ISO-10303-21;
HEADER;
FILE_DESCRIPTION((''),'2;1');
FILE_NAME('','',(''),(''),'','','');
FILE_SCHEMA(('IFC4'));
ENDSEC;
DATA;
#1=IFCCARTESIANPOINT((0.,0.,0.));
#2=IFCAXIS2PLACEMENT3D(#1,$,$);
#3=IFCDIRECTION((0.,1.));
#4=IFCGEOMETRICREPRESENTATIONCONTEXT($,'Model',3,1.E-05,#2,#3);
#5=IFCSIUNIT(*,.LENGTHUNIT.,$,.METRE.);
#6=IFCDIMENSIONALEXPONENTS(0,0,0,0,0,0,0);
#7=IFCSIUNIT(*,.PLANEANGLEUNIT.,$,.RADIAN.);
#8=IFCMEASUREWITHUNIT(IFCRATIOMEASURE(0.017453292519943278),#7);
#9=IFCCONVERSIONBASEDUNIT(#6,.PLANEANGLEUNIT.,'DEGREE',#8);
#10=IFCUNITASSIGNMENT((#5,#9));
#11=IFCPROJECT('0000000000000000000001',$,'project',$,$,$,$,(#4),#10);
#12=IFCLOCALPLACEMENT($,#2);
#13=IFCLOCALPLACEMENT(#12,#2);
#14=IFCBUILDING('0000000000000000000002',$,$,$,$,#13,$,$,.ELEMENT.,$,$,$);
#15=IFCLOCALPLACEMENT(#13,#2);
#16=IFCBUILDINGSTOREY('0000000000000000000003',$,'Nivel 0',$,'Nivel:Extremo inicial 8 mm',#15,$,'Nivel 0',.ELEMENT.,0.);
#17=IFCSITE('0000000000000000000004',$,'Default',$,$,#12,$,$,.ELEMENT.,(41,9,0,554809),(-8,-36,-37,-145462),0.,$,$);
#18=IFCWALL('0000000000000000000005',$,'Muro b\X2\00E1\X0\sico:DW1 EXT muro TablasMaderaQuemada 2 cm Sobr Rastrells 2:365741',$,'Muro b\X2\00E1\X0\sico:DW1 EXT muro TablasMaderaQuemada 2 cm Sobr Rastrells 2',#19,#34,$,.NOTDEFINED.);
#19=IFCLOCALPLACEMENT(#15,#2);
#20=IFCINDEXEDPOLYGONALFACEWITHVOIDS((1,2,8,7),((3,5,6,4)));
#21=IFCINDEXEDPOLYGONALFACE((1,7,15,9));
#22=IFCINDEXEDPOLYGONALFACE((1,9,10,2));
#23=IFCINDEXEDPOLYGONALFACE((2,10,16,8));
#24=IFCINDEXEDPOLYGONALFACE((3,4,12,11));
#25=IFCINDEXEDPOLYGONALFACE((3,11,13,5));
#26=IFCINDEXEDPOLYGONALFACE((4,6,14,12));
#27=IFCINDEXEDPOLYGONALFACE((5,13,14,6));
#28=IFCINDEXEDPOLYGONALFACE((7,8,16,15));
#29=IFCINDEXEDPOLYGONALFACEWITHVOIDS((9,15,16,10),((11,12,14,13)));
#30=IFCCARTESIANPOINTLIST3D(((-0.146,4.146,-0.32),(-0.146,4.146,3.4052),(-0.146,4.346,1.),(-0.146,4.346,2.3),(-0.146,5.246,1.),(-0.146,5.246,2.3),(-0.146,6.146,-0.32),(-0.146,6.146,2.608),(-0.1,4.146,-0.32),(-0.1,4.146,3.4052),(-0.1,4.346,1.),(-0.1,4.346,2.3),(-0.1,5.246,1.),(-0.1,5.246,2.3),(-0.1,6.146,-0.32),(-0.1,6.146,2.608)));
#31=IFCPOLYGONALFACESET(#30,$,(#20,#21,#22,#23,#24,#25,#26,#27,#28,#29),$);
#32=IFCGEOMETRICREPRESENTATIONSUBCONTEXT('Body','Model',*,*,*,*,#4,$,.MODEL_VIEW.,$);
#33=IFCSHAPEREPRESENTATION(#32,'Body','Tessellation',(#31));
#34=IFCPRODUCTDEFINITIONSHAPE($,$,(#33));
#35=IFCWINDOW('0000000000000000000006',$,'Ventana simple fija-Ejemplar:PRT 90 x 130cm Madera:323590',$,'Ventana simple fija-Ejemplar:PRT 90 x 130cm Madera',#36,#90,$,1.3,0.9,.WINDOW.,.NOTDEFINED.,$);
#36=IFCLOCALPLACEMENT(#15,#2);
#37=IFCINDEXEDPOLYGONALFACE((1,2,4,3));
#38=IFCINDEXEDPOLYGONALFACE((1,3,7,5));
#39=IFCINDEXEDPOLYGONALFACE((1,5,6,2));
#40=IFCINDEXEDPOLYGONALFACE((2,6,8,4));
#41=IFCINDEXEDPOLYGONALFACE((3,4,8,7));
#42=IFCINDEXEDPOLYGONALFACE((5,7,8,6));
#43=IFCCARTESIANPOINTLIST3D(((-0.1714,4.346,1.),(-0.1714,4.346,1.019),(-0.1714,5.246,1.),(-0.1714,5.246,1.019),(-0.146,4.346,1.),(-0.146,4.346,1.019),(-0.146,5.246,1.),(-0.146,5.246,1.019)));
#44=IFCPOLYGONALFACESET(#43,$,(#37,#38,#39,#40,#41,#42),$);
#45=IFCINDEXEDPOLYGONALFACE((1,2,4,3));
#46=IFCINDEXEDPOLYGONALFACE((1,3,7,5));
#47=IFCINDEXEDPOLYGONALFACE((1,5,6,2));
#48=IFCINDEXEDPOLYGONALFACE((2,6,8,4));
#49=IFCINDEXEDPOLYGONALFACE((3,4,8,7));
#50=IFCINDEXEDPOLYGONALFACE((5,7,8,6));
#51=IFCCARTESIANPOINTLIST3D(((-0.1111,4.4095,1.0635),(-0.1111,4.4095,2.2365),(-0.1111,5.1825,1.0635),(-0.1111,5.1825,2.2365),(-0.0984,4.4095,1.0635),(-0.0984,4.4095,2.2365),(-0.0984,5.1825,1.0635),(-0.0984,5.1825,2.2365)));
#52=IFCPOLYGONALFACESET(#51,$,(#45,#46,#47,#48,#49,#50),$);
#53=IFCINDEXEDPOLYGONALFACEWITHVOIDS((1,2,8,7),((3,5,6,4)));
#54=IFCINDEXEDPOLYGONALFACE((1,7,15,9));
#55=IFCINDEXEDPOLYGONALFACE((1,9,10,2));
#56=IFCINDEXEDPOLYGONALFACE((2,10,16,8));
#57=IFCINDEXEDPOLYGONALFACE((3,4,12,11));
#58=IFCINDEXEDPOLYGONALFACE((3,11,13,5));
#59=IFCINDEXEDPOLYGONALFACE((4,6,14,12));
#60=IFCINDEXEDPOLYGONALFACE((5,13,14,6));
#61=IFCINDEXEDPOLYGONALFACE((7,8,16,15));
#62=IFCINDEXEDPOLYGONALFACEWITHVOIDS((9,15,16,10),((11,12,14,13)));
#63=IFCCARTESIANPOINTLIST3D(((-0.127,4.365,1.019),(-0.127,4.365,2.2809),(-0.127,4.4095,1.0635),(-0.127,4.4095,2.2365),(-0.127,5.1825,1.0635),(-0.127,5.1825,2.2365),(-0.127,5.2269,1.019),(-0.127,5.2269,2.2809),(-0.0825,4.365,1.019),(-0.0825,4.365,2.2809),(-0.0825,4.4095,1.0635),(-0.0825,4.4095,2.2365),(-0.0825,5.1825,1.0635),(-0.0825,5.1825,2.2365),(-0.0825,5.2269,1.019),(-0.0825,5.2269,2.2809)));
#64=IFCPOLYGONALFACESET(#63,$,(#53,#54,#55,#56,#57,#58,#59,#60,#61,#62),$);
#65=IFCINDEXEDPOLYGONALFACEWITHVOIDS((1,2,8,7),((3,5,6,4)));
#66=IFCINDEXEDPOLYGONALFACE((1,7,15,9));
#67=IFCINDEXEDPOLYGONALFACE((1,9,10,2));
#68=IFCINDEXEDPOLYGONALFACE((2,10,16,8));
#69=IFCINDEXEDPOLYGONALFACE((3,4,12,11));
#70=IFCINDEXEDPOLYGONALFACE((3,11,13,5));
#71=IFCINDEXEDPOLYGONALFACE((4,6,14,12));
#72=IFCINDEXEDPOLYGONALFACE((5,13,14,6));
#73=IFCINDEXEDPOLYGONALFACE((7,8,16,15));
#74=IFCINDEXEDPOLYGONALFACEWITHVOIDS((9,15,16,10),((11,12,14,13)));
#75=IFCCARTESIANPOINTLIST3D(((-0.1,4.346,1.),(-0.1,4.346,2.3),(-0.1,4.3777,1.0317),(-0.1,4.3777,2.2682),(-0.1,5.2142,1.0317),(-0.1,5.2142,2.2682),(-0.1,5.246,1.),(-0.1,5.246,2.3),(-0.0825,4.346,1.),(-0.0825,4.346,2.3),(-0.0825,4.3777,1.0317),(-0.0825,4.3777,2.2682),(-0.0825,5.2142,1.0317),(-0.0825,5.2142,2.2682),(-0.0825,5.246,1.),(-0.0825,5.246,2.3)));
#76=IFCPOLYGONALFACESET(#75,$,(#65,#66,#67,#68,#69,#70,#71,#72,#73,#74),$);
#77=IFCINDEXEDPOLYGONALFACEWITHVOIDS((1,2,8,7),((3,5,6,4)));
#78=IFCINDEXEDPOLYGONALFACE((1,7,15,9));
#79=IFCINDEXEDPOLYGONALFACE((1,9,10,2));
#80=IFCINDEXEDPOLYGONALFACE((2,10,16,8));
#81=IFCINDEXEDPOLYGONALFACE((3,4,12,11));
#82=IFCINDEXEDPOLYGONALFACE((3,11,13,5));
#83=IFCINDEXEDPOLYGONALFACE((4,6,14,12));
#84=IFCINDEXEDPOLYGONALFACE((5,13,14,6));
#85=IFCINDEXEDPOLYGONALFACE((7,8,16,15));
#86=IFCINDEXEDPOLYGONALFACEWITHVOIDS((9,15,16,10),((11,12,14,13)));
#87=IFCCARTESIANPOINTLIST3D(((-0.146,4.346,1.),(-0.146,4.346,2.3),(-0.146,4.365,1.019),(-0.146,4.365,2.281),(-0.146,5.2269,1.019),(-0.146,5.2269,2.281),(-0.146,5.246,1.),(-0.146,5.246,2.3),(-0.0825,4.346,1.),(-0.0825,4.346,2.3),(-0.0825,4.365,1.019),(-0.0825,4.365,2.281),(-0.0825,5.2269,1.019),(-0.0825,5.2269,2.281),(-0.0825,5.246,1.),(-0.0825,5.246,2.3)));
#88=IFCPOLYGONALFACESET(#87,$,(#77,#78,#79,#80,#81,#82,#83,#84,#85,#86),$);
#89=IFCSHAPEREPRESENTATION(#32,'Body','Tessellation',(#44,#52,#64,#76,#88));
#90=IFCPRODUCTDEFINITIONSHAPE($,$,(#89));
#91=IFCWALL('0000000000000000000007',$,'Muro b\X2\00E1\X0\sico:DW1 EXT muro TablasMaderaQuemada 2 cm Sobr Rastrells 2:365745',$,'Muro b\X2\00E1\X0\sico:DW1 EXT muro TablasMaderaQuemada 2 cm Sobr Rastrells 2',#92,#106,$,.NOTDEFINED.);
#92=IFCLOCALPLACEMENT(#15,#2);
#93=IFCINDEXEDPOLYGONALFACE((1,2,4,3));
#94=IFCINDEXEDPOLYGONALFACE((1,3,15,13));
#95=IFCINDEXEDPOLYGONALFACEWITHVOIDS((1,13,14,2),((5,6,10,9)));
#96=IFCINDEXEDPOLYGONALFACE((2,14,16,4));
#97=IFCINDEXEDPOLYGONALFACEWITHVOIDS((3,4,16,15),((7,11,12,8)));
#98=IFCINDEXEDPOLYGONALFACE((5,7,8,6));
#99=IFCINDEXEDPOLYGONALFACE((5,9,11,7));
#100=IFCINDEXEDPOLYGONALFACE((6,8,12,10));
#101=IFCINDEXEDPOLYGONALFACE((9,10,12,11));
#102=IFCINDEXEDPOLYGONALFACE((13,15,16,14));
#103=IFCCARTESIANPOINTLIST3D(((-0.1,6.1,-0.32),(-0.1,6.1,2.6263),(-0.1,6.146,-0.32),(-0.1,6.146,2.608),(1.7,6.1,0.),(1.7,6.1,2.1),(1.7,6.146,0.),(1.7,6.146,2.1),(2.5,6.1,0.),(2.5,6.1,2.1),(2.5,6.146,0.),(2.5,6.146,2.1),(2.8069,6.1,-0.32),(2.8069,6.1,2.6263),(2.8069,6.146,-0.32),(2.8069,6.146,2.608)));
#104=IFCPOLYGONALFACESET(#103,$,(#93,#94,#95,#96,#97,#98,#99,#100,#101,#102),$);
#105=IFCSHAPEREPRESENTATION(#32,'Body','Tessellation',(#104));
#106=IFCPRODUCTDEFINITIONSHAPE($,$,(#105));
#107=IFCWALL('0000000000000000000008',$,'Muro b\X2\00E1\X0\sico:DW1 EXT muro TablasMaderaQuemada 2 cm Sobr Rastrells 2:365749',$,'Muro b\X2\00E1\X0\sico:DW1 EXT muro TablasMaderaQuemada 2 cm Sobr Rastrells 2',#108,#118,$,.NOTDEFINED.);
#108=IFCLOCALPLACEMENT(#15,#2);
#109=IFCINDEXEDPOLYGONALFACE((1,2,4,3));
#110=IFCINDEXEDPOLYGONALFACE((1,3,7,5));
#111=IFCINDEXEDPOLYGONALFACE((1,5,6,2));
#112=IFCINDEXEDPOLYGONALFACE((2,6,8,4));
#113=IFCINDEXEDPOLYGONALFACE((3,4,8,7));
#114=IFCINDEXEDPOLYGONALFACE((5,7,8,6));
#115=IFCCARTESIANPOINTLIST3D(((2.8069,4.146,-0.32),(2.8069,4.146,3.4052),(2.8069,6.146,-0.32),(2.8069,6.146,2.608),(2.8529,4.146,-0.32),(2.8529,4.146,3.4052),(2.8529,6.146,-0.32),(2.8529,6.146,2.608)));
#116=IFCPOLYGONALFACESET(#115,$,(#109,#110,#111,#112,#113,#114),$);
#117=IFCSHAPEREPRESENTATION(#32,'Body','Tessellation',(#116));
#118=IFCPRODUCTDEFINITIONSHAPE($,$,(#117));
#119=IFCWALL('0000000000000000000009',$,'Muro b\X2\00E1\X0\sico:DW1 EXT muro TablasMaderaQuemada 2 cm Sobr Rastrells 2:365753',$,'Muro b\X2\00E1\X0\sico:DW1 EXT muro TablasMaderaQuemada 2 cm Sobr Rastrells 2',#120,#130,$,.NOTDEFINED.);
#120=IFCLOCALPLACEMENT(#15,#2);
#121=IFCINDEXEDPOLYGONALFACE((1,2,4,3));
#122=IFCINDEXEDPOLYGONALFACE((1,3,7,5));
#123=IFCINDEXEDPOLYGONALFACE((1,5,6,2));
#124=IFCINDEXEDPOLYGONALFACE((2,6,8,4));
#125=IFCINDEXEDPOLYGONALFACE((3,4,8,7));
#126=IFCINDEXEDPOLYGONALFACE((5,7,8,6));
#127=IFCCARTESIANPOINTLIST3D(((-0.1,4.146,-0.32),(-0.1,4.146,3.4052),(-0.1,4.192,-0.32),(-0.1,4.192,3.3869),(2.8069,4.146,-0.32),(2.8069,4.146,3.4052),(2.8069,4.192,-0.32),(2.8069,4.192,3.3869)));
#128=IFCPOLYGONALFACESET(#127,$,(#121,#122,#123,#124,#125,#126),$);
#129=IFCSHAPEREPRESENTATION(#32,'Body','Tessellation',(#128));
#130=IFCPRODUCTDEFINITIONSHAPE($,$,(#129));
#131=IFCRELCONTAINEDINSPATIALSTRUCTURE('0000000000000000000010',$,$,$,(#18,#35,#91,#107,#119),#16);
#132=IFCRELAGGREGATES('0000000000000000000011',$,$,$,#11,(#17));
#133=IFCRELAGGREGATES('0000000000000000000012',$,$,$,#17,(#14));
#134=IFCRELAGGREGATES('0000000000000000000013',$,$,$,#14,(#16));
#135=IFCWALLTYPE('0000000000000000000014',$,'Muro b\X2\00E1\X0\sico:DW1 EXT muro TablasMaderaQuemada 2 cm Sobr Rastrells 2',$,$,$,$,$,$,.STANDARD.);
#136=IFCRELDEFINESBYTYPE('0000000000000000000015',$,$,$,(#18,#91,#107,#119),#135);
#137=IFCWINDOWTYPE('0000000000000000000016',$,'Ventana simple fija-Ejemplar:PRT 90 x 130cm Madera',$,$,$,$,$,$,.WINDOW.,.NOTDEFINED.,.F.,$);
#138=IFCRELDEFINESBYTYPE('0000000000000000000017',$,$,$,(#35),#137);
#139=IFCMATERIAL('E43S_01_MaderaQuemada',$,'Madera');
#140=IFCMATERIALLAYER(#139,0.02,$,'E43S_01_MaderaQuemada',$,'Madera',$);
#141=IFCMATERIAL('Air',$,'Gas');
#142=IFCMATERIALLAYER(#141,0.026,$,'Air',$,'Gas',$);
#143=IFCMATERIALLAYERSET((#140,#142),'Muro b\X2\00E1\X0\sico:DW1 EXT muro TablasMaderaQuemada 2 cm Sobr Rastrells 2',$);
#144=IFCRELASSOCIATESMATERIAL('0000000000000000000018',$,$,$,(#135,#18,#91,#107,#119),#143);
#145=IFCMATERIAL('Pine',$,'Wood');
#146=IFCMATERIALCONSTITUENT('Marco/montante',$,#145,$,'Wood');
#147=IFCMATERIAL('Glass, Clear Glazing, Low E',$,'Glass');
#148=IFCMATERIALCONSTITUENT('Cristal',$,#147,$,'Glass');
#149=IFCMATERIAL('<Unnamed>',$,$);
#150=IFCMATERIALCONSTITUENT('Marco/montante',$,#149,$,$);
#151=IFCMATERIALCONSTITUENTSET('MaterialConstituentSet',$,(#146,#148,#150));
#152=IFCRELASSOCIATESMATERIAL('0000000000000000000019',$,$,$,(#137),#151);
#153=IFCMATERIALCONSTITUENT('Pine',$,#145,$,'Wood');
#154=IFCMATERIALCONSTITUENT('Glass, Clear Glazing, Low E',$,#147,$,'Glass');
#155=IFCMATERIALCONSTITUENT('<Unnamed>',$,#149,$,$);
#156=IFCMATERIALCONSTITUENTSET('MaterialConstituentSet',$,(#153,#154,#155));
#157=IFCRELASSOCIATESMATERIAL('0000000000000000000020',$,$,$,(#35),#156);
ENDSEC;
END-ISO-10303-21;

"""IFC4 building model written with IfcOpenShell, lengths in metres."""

from ifc_helpers import new_model, entity, si_unit, converted_unit, direction, frame, frame_2d, origin, origin_2d_with_axis, place, context, subcontext, project, spatial, polyline, rectangle, outline, extrude, clip, bounded_halfspace, source, transform, mapped, material, layer, layer_set, layer_usage, constituent, constituent_set, type_object, type_shapes, element, fill, save


model = new_model("IFC4")

# Units and contexts
model_context = context("Model", 3, precision=1e-05, world=origin(), true_north=direction((0.0, 1.0)))
body_context = subcontext(model_context, "Body", "Model", "MODEL_VIEW")
ifc_project = project(units=[si_unit("LENGTHUNIT", "METRE"), converted_unit("PLANEANGLEUNIT", "DEGREE", entity("IfcRatioMeasure", 0.017453292519943278), si_unit("PLANEANGLEUNIT", "RADIAN"), dimensions=[0, 0, 0, 0, 0, 0, 0])], contexts=[model_context])

# Site, building, storey
site_placement = place(None, origin())
site = spatial("IfcSite", under=ifc_project, at=site_placement, Name="Default", CompositionType="ELEMENT", RefLatitude=(41, 9, 0, 554809), RefLongitude=(-8, -36, -37, -145462), RefElevation=0.0)
building_placement = place(site_placement, origin())
building = spatial("IfcBuilding", under=site, at=building_placement, CompositionType="ELEMENT")
storey_placement = place(building_placement, origin())
storey = spatial("IfcBuildingStorey", under=building, at=storey_placement, Name="Nivel 0", ObjectType="Nivel:Extremo inicial 8 mm", LongName="Nivel 0", CompositionType="ELEMENT", Elevation=0.0)

# Shared definitions
ifc_material_1 = material(Name="Pine", Category="Wood")
ifc_material_2 = material(Name="Glass, Clear Glazing, Low E", Category="Glass")
ifc_material_3 = material(Name="<Unnamed>")

# Wall, opening, window
ifc_material_4 = material(Name="E43S_01_MaderaQuemada", Category="Madera")
ifc_layer_1 = layer(ifc_material_4, 0.02, Name="E43S_01_MaderaQuemada", Category="Madera")
ifc_material_5 = material(Name="Air", Category="Gas")
ifc_layer_2 = layer(ifc_material_5, 0.026, Name="Air", Category="Gas")
ifc_layer_set_1 = layer_set([ifc_layer_1, ifc_layer_2], Name="Muro básico:DW1 EXT muro TablasMaderaQuemada 2 cm Sobr Rastrells 2")
ifc_layer_usage_1 = layer_usage(ifc_layer_set_1, "AXIS2", "NEGATIVE", 0.023)
wall_type_1 = type_object("IfcWallType", Name="Muro básico:DW1 EXT muro TablasMaderaQuemada 2 cm Sobr Rastrells 2", PredefinedType="STANDARD", material=ifc_layer_set_1)
wall_1_placement = place(storey_placement, frame((-0.123, 4.146, -0.32), z_axis=(0.0, 0.0, 1.0), x_axis=(0.0, 1.0, 0.0)))
wall_1 = element("IfcWall", 1, at=wall_1_placement, inside=storey, type_object=wall_type_1, material=ifc_layer_usage_1, Name="Muro básico:DW1 EXT muro TablasMaderaQuemada 2 cm Sobr Rastrells 2:365741", ObjectType="Muro básico:DW1 EXT muro TablasMaderaQuemada 2 cm Sobr Rastrells 2", PredefinedType="NOTDEFINED", context=body_context, shape_type="Clipping", body=[
    clip(extrude(rectangle(XDim=2.0, YDim=0.046, at=frame_2d((1.0, 0.0), x_axis=(1.0, 0.0))), origin(), (0.0, 0.0, 1.0), 3.7252), bounded_halfspace(frame((0.0, -0.023, 3.7252), z_axis=(0.370288, 0.0, 0.928917), x_axis=(0.0, 1.0, 0.0)), False, frame((0.0, -0.023, 3.7252)), polyline([(0.0, 0.0), (0.046, 0.0), (1.954, 0.0), (2.0, 0.0), (2.0, 0.046), (0.0, 0.046), (0.0, 0.0)]))),
])
opening_1_placement = place(wall_1_placement, frame((0.2, -0.023, 1.32)))
opening_1 = element("IfcOpeningElement", 2, at=opening_1_placement, cuts=wall_1, PredefinedType="OPENING", context=body_context, shape_type="SweptSolid", body=[
    extrude(rectangle(XDim=1.3, YDim=0.9, at=frame_2d((0.65, 0.45), x_axis=(-1.0, 0.0))), frame((0.0, 0.0, 0.0), z_axis=(0.0, 1.0, 0.0), x_axis=(0.0, 0.0, 1.0)), (0.0, 0.0, 1.0), 0.046),
])
ifc_constituent_1 = constituent(ifc_material_1, Name="Pine", Category="Wood")
ifc_constituent_2 = constituent(ifc_material_2, Name="Glass, Clear Glazing, Low E", Category="Glass")
ifc_constituent_3 = constituent(ifc_material_3, Name="<Unnamed>")
ifc_constituent_set_1 = constituent_set(constituents=[ifc_constituent_1, ifc_constituent_2, ifc_constituent_3], Name="MaterialConstituentSet")
ifc_constituent_4 = constituent(ifc_material_1, Name="Marco/montante", Category="Wood")
ifc_constituent_5 = constituent(ifc_material_2, Name="Cristal", Category="Glass")
ifc_constituent_6 = constituent(ifc_material_3, Name="Marco/montante")
ifc_constituent_set_2 = constituent_set(constituents=[ifc_constituent_4, ifc_constituent_5, ifc_constituent_6], Name="MaterialConstituentSet")
window_type_1 = type_object("IfcWindowType", Name="Ventana simple fija-Ejemplar:PRT 90 x 130cm Madera", ParameterTakesPrecedence=False, PartitioningType="NOTDEFINED", PredefinedType="WINDOW", material=ifc_constituent_set_2)
shared_shape_1 = source(origin(), body_context, "Body", "SweptSolid", [
    extrude(rectangle(XDim=0.9, YDim=0.0254, at=origin_2d_with_axis()), frame((0.5262, 0.0587, 0.0), z_axis=(0.0, 0.0, 1.0), x_axis=(-1.0, 0.0, 0.0)), (0.0, 0.0, 1.0), 0.019),
    extrude(rectangle(XDim=0.773, YDim=0.0127, at=origin_2d_with_axis()), frame((0.5262, 0.0048, 0.0635)), (0.0, 0.0, 1.0), 1.173),
    extrude(outline(polyline([(-0.431, -0.631), (0.431, -0.631), (0.431, 0.631), (-0.431, 0.631), (-0.431, -0.631)]), holes=[polyline([(-0.3865, -0.5865), (-0.3865, 0.5865), (0.3865, 0.5865), (0.3865, -0.5865), (-0.3865, -0.5865)])]), frame((0.5262, 0.027, 0.65), z_axis=(0.0, -1.0, 0.0), x_axis=(-1.0, 0.0, 0.0)), (0.0, 0.0, 1.0), 0.0444),
    extrude(outline(polyline([(-0.45, -0.65), (0.45, -0.65), (0.45, 0.65), (-0.45, 0.65), (-0.45, -0.65)]), holes=[polyline([(-0.4183, -0.6182), (-0.4183, 0.6183), (0.4183, 0.6183), (0.4183, -0.6182), (-0.4183, -0.6182)])]), frame((0.5262, 0.0, 0.65), z_axis=(0.0, -1.0, 0.0), x_axis=(-1.0, 0.0, 0.0)), (0.0, 0.0, 1.0), 0.0175),
    extrude(outline(polyline([(-0.65, -0.45), (0.65, -0.45), (0.65, 0.45), (-0.65, 0.45), (-0.65, -0.45)]), holes=[polyline([(-0.6309, -0.431), (-0.6309, 0.431), (0.631, 0.431), (0.631, -0.431), (-0.6309, -0.431)])]), frame((0.5262, 0.046, 0.65), z_axis=(0.0, -1.0, 0.0), x_axis=(0.0, 0.0, -1.0)), (0.0, 0.0, 1.0), 0.0635),
])
type_shapes(window_type_1, [shared_shape_1])
window_1_placement = place(opening_1_placement, frame((-0.0762, 0.0, 0.0)))
window_1 = element("IfcWindow", 3, at=window_1_placement, inside=storey, type_object=window_type_1, material=ifc_constituent_set_1, Name="Ventana simple fija-Ejemplar:PRT 90 x 130cm Madera:323590", ObjectType="Ventana simple fija-Ejemplar:PRT 90 x 130cm Madera", OverallHeight=1.3, OverallWidth=0.9, PartitioningType="NOTDEFINED", PredefinedType="WINDOW", context=body_context, shape_type="MappedRepresentation", body=[
    mapped(shared_shape_1, transform((0.0, 0.0, 0.0), scale=1.0)),
])
fill(opening_1, window_1)

# Wall, opening
ifc_layer_usage_2 = layer_usage(ifc_layer_set_1, "AXIS2", "NEGATIVE", 0.023)
wall_2_placement = place(storey_placement, frame((-0.1, 6.123, -0.32)))
wall_2 = element("IfcWall", 4, at=wall_2_placement, inside=storey, type_object=wall_type_1, material=ifc_layer_usage_2, Name="Muro básico:DW1 EXT muro TablasMaderaQuemada 2 cm Sobr Rastrells 2:365745", ObjectType="Muro básico:DW1 EXT muro TablasMaderaQuemada 2 cm Sobr Rastrells 2", PredefinedType="NOTDEFINED", context=body_context, shape_type="Clipping", body=[
    clip(extrude(rectangle(XDim=2.9069, YDim=0.046, at=frame_2d((1.4535, 0.0), x_axis=(-1.0, 0.0))), origin(), (0.0, 0.0, 1.0), 2.9463), bounded_halfspace(frame((0.0, -0.023, 2.9463), z_axis=(0.0, 0.370288, 0.928917), x_axis=(-1.0, 0.0, 0.0)), False, frame((0.0, -0.023, 2.9463), z_axis=(0.0, 0.370288, 0.928917), x_axis=(-1.0, 0.0, 0.0)), polyline([(0.0, 0.0), (-0.2, 0.0), (-2.7069, 0.0), (-2.9069, 0.0), (-2.9069, -0.0495), (0.0, -0.0495), (0.0, 0.0)]))),
])
opening_2_placement = place(wall_2_placement, frame((1.8, -1.547, 0.32)))
element("IfcOpeningElement", 5, at=opening_2_placement, cuts=wall_2, PredefinedType="OPENING", context=body_context, shape_type="SweptSolid", body=[
    extrude(rectangle(XDim=2.1, YDim=0.8, at=frame_2d((0.0, 0.0), x_axis=(1.0, 0.0))), frame((0.4, 0.0, 1.05), z_axis=(0.0, 1.0, 0.0), x_axis=(0.0, 0.0, -1.0)), (0.0, 0.0, 1.0), 3.048),
])

# Walls
ifc_layer_usage_3 = layer_usage(ifc_layer_set_1, "AXIS2", "NEGATIVE", 0.023)
wall_3_placement = place(storey_placement, frame((2.8299, 6.146, -0.32), z_axis=(0.0, 0.0, 1.0), x_axis=(0.0, -1.0, 0.0)))
element("IfcWall", 6, at=wall_3_placement, inside=storey, type_object=wall_type_1, material=ifc_layer_usage_3, Name="Muro básico:DW1 EXT muro TablasMaderaQuemada 2 cm Sobr Rastrells 2:365749", ObjectType="Muro básico:DW1 EXT muro TablasMaderaQuemada 2 cm Sobr Rastrells 2", PredefinedType="NOTDEFINED", context=body_context, shape_type="Clipping", body=[
    clip(extrude(rectangle(XDim=2.0, YDim=0.046, at=frame_2d((1.0, 0.0), x_axis=(-1.0, 0.0))), origin(), (0.0, 0.0, 1.0), 3.7252), bounded_halfspace(frame((0.0, 0.023, 2.928), z_axis=(-0.370288, 0.0, 0.928917), x_axis=(0.0, -1.0, 0.0)), False, frame((0.0, 0.023, 2.928)), polyline([(0.0, 0.0), (0.0, -0.046), (0.046, -0.046), (1.954, -0.046), (2.0, -0.046), (2.0, 0.0), (0.0, 0.0)]))),
])
ifc_layer_usage_4 = layer_usage(ifc_layer_set_1, "AXIS2", "NEGATIVE", 0.023)
wall_4_placement = place(storey_placement, frame((2.8069, 4.169, -0.32), z_axis=(0.0, 0.0, 1.0), x_axis=(-1.0, 0.0, 0.0)))
element("IfcWall", 7, at=wall_4_placement, inside=storey, type_object=wall_type_1, material=ifc_layer_usage_4, Name="Muro básico:DW1 EXT muro TablasMaderaQuemada 2 cm Sobr Rastrells 2:365753", ObjectType="Muro básico:DW1 EXT muro TablasMaderaQuemada 2 cm Sobr Rastrells 2", PredefinedType="NOTDEFINED", context=body_context, shape_type="Clipping", body=[
    clip(extrude(rectangle(XDim=2.9069, YDim=0.046, at=frame_2d((1.4535, 0.0), x_axis=(-1.0, 0.0))), origin(), (0.0, 0.0, 1.0), 3.7252), bounded_halfspace(frame((0.0, -0.023, 3.7069), z_axis=(0.0, -0.370288, 0.928917), x_axis=(1.0, 0.0, 0.0)), False, frame((0.0, -0.023, 3.7069), z_axis=(0.0, -0.370288, 0.928917), x_axis=(1.0, 0.0, 0.0)), polyline([(0.0, 0.0), (2.9069, 0.0), (2.9069, 0.0495), (0.0, 0.0495), (0.0, 0.0)]))),
])

save(model, "model.ifc")
